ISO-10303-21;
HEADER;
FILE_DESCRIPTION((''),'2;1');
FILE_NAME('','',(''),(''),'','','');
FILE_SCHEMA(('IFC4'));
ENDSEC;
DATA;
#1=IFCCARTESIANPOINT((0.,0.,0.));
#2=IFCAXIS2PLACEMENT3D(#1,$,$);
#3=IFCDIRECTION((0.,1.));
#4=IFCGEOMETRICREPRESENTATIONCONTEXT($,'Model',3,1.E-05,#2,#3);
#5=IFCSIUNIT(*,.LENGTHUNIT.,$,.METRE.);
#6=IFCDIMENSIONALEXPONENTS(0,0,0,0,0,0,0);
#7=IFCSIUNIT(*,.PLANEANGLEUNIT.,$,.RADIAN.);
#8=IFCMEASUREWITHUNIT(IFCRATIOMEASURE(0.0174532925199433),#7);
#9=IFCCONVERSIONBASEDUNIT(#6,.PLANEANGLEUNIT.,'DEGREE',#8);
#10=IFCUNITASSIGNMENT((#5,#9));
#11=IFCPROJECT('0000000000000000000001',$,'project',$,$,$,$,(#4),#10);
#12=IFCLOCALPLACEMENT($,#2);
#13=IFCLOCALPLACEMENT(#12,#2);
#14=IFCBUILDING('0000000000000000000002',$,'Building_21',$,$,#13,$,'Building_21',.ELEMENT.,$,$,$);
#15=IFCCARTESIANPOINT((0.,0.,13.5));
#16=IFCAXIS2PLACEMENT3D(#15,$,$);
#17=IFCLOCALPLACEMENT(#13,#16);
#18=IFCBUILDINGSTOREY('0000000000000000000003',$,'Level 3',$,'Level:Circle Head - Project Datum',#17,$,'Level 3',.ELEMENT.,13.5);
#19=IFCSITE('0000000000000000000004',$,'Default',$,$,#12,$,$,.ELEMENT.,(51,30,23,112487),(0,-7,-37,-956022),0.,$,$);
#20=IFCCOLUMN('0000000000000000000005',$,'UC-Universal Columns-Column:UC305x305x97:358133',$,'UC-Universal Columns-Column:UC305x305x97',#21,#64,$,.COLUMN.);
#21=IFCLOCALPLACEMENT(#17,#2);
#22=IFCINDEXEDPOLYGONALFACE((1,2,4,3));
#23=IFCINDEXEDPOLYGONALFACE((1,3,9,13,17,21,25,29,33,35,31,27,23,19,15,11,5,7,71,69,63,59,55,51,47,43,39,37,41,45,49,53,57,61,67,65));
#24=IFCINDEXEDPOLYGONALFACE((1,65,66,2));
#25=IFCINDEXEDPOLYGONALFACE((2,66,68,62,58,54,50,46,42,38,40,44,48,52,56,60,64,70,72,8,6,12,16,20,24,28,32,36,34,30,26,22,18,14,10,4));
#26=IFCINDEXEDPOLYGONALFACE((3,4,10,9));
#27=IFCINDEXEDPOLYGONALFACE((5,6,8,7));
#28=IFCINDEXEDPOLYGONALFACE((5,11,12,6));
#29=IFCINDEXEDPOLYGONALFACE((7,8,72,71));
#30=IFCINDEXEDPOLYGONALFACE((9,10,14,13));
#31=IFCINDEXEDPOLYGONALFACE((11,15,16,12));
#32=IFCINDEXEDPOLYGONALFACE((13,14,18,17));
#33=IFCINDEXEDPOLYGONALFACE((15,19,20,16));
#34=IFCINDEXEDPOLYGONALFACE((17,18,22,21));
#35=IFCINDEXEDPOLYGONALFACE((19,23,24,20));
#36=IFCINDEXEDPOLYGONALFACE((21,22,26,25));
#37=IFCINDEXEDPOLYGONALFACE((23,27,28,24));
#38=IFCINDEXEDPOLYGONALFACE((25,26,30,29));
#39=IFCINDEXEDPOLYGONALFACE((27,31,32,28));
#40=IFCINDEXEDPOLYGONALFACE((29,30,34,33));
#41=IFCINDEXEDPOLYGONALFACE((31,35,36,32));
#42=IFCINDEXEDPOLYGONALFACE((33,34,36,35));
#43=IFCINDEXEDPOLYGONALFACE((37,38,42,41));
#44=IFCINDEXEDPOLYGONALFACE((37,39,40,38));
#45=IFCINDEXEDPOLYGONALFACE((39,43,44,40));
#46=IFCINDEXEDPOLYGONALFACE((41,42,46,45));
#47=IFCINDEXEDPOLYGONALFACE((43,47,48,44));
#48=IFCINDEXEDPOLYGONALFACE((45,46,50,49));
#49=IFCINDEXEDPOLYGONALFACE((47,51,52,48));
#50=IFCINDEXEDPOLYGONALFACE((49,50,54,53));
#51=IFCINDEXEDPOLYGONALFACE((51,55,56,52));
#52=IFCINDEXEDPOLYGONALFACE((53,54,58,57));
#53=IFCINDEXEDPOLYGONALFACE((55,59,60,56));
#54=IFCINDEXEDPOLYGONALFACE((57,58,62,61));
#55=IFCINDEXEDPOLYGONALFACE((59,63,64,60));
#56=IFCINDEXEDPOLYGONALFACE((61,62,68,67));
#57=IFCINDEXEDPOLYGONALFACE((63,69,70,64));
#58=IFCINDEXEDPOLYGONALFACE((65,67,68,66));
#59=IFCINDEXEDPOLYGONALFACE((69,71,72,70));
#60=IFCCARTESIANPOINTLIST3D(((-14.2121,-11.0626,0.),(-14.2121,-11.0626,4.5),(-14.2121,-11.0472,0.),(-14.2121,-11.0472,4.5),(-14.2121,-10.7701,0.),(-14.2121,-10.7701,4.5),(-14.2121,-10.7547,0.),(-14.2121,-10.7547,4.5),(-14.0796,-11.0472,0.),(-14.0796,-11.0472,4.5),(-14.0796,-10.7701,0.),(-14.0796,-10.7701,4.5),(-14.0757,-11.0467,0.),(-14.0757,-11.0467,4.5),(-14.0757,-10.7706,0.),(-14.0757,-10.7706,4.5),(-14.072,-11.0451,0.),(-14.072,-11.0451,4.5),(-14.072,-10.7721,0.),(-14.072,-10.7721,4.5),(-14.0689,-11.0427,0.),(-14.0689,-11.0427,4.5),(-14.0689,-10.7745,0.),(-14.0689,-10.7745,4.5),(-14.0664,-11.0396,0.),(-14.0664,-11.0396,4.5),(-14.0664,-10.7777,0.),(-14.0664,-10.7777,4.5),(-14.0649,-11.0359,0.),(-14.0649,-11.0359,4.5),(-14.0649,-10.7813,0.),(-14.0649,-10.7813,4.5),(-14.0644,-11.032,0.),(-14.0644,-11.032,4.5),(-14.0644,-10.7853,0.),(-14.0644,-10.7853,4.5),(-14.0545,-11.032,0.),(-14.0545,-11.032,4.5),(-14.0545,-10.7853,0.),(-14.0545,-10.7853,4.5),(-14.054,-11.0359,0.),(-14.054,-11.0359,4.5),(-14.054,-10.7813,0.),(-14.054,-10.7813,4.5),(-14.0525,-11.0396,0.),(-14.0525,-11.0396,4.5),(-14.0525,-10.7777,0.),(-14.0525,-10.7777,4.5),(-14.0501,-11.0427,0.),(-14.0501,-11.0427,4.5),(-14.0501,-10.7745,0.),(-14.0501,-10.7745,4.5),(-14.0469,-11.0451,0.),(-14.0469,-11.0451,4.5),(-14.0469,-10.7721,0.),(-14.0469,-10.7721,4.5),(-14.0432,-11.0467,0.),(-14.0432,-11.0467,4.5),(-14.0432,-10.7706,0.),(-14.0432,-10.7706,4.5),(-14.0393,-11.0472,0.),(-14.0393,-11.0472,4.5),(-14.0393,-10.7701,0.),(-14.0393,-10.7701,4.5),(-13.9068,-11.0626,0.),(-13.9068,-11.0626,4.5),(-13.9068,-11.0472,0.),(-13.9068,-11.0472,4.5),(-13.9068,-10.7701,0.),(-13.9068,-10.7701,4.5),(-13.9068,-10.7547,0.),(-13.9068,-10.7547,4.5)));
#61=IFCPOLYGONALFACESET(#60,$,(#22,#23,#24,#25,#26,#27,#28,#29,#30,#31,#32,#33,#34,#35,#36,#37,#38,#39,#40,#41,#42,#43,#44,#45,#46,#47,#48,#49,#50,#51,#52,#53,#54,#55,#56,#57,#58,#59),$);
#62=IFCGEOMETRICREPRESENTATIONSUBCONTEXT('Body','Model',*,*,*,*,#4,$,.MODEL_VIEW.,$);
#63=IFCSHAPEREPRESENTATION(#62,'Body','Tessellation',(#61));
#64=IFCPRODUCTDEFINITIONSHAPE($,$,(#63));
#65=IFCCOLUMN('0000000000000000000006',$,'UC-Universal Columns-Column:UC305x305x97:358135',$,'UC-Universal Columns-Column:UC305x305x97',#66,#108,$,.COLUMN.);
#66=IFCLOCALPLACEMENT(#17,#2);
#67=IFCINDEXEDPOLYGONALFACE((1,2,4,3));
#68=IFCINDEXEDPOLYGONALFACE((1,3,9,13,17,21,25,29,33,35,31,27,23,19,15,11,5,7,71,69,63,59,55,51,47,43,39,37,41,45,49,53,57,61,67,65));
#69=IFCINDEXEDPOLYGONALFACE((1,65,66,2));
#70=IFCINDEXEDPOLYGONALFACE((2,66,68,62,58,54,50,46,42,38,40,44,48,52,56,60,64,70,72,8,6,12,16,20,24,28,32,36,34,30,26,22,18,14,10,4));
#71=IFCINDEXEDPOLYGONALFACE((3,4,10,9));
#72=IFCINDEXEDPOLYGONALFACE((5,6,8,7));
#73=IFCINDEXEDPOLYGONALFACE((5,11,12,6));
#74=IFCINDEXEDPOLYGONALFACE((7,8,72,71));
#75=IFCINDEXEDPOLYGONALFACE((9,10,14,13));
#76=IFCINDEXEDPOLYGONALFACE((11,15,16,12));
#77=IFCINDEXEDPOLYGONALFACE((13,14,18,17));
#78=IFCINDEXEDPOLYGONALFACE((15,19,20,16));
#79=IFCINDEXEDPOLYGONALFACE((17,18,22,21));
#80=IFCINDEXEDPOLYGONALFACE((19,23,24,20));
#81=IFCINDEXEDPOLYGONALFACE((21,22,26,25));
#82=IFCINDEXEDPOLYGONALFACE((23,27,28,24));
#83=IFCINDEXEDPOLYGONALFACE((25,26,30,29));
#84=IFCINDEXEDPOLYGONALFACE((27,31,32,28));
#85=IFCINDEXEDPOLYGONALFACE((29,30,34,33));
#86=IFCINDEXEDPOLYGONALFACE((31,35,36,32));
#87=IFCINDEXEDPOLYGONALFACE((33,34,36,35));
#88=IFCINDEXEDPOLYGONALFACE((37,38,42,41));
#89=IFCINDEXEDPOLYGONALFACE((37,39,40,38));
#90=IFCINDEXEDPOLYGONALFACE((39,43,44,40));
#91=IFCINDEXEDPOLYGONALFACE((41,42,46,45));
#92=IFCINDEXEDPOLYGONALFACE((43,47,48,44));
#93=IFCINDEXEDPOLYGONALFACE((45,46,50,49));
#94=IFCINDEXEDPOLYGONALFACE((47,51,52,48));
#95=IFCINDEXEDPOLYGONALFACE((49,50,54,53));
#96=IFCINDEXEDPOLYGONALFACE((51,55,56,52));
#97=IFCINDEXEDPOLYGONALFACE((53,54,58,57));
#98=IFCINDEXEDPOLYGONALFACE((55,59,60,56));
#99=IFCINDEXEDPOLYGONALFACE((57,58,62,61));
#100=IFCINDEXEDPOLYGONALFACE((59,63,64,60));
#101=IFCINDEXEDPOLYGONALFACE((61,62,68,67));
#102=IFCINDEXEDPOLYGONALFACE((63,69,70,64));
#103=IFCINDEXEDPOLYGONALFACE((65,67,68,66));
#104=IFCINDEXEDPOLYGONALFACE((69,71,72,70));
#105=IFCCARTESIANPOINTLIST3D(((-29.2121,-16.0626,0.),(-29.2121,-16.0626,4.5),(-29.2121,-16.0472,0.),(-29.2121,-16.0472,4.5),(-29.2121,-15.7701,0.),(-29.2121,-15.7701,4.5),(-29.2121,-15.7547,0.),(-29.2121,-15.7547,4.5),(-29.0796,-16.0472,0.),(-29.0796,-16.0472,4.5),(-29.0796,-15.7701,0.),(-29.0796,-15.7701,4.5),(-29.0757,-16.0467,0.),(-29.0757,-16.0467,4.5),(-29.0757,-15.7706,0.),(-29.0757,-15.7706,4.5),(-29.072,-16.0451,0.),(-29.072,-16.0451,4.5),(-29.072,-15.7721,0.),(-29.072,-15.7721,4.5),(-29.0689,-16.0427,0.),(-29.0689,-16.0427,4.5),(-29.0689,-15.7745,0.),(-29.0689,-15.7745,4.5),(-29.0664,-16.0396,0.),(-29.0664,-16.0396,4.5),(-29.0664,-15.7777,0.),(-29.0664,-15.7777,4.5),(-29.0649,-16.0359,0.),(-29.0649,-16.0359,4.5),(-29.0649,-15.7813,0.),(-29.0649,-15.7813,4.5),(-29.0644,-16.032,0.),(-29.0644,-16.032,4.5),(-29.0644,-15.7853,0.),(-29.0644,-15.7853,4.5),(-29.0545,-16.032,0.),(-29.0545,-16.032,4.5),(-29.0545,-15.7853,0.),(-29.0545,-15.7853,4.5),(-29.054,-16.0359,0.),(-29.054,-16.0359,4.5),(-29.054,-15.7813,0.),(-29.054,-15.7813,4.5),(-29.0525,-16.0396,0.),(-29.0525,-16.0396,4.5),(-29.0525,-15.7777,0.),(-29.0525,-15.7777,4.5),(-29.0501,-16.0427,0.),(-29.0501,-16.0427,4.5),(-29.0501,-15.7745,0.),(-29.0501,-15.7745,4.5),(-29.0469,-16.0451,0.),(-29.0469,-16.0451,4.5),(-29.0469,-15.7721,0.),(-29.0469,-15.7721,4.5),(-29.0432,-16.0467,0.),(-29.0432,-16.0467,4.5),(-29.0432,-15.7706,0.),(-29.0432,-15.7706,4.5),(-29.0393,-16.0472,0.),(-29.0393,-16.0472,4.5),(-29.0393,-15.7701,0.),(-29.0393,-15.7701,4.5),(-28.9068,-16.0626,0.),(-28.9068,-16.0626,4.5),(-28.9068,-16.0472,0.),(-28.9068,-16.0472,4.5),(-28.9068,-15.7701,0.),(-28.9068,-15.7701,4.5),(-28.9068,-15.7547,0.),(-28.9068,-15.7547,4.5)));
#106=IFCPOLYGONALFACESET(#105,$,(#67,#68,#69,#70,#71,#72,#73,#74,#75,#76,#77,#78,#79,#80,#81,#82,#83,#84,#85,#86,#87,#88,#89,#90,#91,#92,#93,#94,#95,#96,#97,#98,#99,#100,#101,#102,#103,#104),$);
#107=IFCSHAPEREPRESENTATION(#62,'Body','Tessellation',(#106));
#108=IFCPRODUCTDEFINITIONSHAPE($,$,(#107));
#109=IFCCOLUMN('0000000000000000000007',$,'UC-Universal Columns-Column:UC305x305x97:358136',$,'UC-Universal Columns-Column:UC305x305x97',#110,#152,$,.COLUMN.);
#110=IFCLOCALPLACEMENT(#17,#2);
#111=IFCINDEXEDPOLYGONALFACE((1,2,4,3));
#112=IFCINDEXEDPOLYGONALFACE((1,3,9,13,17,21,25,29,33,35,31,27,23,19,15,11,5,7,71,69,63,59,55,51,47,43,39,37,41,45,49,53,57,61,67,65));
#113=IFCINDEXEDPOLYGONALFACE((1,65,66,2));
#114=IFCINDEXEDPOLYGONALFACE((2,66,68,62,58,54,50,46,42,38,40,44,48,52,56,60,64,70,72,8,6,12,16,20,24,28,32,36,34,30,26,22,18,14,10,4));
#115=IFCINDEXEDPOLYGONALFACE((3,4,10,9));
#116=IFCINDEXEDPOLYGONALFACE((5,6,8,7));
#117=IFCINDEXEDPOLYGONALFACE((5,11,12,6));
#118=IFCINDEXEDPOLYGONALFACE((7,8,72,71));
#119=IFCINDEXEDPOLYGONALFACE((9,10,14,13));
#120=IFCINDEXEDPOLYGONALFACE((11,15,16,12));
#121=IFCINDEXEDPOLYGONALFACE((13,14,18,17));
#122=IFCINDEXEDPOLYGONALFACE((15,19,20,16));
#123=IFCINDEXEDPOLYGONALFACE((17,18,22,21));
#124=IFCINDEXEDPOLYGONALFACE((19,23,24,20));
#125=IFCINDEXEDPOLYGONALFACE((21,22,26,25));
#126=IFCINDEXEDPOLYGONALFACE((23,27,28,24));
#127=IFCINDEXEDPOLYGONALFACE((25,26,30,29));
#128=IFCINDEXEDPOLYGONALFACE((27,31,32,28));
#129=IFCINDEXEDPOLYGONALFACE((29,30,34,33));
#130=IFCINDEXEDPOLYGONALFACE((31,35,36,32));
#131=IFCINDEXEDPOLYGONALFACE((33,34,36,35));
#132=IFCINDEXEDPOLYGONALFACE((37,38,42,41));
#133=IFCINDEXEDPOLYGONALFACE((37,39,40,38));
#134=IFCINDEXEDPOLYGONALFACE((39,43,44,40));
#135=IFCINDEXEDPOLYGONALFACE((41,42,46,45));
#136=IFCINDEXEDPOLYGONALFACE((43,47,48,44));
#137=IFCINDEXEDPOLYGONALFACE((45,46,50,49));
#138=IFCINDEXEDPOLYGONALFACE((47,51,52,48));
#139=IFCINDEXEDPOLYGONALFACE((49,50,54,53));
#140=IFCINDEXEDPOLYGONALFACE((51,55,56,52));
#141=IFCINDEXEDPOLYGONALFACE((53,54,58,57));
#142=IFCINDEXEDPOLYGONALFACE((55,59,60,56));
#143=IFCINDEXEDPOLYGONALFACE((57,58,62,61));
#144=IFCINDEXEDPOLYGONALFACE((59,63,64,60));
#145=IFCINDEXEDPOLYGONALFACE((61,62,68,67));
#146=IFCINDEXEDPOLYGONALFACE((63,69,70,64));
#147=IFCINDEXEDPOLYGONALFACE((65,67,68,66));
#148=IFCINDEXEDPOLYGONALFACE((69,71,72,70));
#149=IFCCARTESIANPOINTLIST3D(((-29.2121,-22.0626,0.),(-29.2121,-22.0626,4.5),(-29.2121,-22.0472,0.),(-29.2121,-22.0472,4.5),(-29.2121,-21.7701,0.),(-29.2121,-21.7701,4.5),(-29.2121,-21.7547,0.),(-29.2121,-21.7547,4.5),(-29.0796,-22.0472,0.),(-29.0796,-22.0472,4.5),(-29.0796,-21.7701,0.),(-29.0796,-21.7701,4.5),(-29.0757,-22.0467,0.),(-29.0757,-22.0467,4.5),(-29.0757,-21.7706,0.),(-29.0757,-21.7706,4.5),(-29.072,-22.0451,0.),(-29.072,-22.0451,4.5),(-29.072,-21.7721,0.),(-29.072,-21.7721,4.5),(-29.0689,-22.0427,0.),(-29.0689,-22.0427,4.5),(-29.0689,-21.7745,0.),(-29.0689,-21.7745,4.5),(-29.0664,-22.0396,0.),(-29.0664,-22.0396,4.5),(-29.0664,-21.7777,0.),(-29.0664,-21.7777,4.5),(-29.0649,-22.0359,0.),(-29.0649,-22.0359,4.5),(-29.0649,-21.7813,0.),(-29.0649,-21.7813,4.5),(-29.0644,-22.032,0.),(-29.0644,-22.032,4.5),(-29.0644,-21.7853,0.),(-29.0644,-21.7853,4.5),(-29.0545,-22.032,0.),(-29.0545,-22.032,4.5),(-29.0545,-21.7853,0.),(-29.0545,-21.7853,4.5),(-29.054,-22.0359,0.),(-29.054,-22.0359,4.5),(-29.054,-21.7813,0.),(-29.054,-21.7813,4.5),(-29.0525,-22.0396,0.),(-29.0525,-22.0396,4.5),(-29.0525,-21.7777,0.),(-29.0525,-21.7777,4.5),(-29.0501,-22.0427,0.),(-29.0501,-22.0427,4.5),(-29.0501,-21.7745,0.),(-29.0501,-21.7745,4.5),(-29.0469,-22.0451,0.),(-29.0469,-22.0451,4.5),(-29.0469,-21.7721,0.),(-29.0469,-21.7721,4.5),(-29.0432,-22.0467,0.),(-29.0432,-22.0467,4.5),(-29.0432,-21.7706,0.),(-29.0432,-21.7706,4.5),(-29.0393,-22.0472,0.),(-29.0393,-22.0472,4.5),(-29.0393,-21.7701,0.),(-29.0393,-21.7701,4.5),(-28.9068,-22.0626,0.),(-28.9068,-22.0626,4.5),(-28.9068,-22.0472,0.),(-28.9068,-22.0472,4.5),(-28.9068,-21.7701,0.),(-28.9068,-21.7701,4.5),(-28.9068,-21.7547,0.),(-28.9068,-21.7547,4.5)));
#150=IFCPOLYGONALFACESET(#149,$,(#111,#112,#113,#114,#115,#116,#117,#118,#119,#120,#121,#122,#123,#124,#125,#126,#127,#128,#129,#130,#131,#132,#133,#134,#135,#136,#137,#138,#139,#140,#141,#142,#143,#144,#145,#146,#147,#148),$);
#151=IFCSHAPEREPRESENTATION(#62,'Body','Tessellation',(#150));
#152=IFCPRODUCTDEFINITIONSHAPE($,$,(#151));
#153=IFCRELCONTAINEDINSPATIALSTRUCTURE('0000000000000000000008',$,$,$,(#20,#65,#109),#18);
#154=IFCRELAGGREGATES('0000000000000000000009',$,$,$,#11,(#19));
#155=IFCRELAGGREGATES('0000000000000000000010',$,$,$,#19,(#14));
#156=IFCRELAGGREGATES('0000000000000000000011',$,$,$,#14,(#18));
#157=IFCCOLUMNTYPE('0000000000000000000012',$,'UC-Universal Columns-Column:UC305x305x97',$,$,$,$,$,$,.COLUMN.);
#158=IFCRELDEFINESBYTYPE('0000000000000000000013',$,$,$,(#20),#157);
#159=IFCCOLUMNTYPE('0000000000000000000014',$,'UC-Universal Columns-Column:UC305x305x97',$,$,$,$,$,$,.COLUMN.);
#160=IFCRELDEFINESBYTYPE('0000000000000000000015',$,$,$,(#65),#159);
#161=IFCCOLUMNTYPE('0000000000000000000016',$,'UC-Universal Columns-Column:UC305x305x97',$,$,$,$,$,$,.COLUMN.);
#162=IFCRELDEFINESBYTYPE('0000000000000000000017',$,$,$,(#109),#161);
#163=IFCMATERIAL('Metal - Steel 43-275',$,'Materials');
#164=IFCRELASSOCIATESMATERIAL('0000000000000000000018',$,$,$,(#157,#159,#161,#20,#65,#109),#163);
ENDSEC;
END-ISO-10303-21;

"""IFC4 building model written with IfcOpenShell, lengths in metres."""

from ifc_helpers import new_model, entity, si_unit, converted_unit, direction, frame, frame_2d, origin, place, context, subcontext, project, spatial, polyline, circle_curve, parameter, trimmed, segment, composite_curve, i_section, outline, extrude, source, transform, mapped, material, material_profile, profile_set, profile_usage, type_object, type_shapes, element, save


model = new_model("IFC4")

# Units and contexts
model_context = context("Model", 3, precision=1e-05, world=origin(), true_north=direction((0.0, 1.0)))
body_context = subcontext(model_context, "Body", "Model", "MODEL_VIEW")
ifc_project = project(units=[si_unit("LENGTHUNIT", "METRE"), converted_unit("PLANEANGLEUNIT", "DEGREE", entity("IfcRatioMeasure", 0.0174532925199433), si_unit("PLANEANGLEUNIT", "RADIAN"), dimensions=[0, 0, 0, 0, 0, 0, 0])], contexts=[model_context])

# Site, building, storey
site_placement = place(None, origin())
site = spatial("IfcSite", under=ifc_project, at=site_placement, Name="Default", CompositionType="ELEMENT", RefLatitude=(51, 30, 23, 112487), RefLongitude=(0, -7, -37, -956022), RefElevation=0.0)
building_placement = place(site_placement, origin())
building = spatial("IfcBuilding", under=site, at=building_placement, Name="Building_21", LongName="Building_21", CompositionType="ELEMENT")
storey_placement = place(building_placement, frame((0.0, 0.0, 13.5)))
storey = spatial("IfcBuildingStorey", under=building, at=storey_placement, Name="Level 3", ObjectType="Level:Circle Head - Project Datum", LongName="Level 3", CompositionType="ELEMENT", Elevation=13.5)

# Columns
ifc_material_1 = material(Name="Metal - Steel 43-275", Category="Materials")
ifc_material_profile_1 = material_profile(ifc_material_1, outline(composite_curve([segment(polyline([(-0.1527, 0.154, 0.0), (0.1527, 0.154, 0.0)]), True, "CONTINUOUS"), segment(polyline([(0.1527, 0.154, 0.0), (0.1527, 0.1386, 0.0)]), True, "CONTINUOUS"), segment(polyline([(0.1527, 0.1386, 0.0), (0.0201, 0.1386, 0.0)]), True, "CONTINUOUS"), segment(trimmed(circle_curve(frame((0.0201, 0.1234, 0.0)), 0.0152), [parameter(90.0)], [parameter(180.0)], True, "PARAMETER"), True, "CONTINUOUS"), segment(polyline([(0.0049, 0.1234, 0.0), (0.0049, -0.1234, 0.0)]), True, "CONTINUOUS"), segment(trimmed(circle_curve(frame((0.0201, -0.1234, 0.0)), 0.0152), [parameter(180.0)], [parameter(270.0)], True, "PARAMETER"), True, "CONTINUOUS"), segment(polyline([(0.0201, -0.1386, 0.0), (0.1527, -0.1386, 0.0)]), True, "CONTINUOUS"), segment(polyline([(0.1527, -0.1386, 0.0), (0.1527, -0.154, 0.0)]), True, "CONTINUOUS"), segment(polyline([(0.1527, -0.154, 0.0), (-0.1527, -0.154, 0.0)]), True, "CONTINUOUS"), segment(polyline([(-0.1527, -0.154, 0.0), (-0.1527, -0.1386, 0.0)]), True, "CONTINUOUS"), segment(polyline([(-0.1527, -0.1386, 0.0), (-0.0201, -0.1386, 0.0)]), True, "CONTINUOUS"), segment(trimmed(circle_curve(frame((-0.0201, -0.1234, 0.0)), 0.0152), [parameter(270.0)], [parameter(0.0)], True, "PARAMETER"), True, "CONTINUOUS"), segment(polyline([(-0.0049, -0.1234, 0.0), (-0.005, 0.1234, 0.0)]), True, "CONTINUOUS"), segment(trimmed(circle_curve(frame((-0.0201, 0.1234, 0.0)), 0.0152), [parameter(0.0)], [parameter(90.0)], True, "PARAMETER"), True, "CONTINUOUS"), segment(polyline([(-0.0201, 0.1386, 0.0), (-0.1527, 0.1386, 0.0)]), True, "CONTINUOUS"), segment(polyline([(-0.1527, 0.1386, 0.0), (-0.1527, 0.154, 0.0)]), True, "CONTINUOUS")], self_intersect=False), kind="CURVE"), Name="UC305x305x97")
ifc_material_profile_2 = material_profile(ifc_material_1, outline(composite_curve([segment(polyline([(0.1527, 0.154, 0.0), (0.1527, 0.1386, 0.0)]), True, "CONTINUOUS"), segment(polyline([(0.1527, 0.1386, 0.0), (0.0049, 0.1386, 0.0)]), True, "CONTINUOUS"), segment(polyline([(0.0049, 0.1386, 0.0), (0.0049, -0.1386, 0.0)]), True, "CONTINUOUS"), segment(polyline([(0.0049, -0.1386, 0.0), (0.1527, -0.1386, 0.0)]), True, "CONTINUOUS"), segment(polyline([(0.1527, -0.1386, 0.0), (0.1527, -0.154, 0.0)]), True, "CONTINUOUS"), segment(polyline([(0.1527, -0.154, 0.0), (-0.1527, -0.154, 0.0)]), True, "CONTINUOUS"), segment(polyline([(-0.1527, -0.154, 0.0), (-0.1527, -0.1386, 0.0)]), True, "CONTINUOUS"), segment(polyline([(-0.1527, -0.1386, 0.0), (-0.005, -0.1386, 0.0)]), True, "CONTINUOUS"), segment(polyline([(-0.005, -0.1386, 0.0), (-0.005, 0.1386, 0.0)]), True, "CONTINUOUS"), segment(polyline([(-0.005, 0.1386, 0.0), (-0.1527, 0.1386, 0.0)]), True, "CONTINUOUS"), segment(polyline([(-0.1527, 0.1386, 0.0), (-0.1527, 0.154, 0.0)]), True, "CONTINUOUS"), segment(polyline([(-0.1527, 0.154, 0.0), (0.1527, 0.154, 0.0)]), True, "CONTINUOUS")], self_intersect=False), kind="CURVE"), Name="UC305x305x97")
ifc_profile_set = profile_set([ifc_material_profile_1, ifc_material_profile_2], Name="UC305x305x97")
ifc_profile_usage_1 = profile_usage(ifc_profile_set)
column_type_1 = type_object("IfcColumnType", Name="UC-Universal Columns-Column:UC305x305x97", PredefinedType="COLUMN", material=ifc_profile_set)
shared_shape_1 = source(origin(), body_context, "Body", "SweptSolid", [
    extrude(i_section(OverallWidth=0.3053, OverallDepth=0.3079, WebThickness=0.0099, FlangeThickness=0.0154, FilletRadius=0.0152, at=frame_2d((0.0, 0.0), x_axis=(0.0, 1.0))), frame((-14.0595, -10.9086, 13.5), z_axis=(0.0, 0.0, 1.0), x_axis=(0.0, -1.0, 0.0)), (0.0, 0.0, 1.0), 4.5),
])
type_shapes(column_type_1, [shared_shape_1])
column_1_placement = place(storey_placement, frame((0.0, 0.0, -13.5)))
element("IfcColumn", 1, at=column_1_placement, inside=storey, type_object=column_type_1, material=ifc_profile_usage_1, Name="UC-Universal Columns-Column:UC305x305x97:358133", ObjectType="UC-Universal Columns-Column:UC305x305x97", PredefinedType="COLUMN", context=body_context, shape_type="MappedRepresentation", body=[
    mapped(shared_shape_1, transform((0.0, 0.0, 0.0), scale=1.0)),
])
ifc_profile_usage_2 = profile_usage(ifc_profile_set)
column_type_2 = type_object("IfcColumnType", Name="UC-Universal Columns-Column:UC305x305x97", PredefinedType="COLUMN", material=ifc_profile_set)
shared_shape_2 = source(origin(), body_context, "Body", "SweptSolid", [
    extrude(i_section(OverallWidth=0.3053, OverallDepth=0.3079, WebThickness=0.0099, FlangeThickness=0.0154, FilletRadius=0.0152, at=frame_2d((0.0, 0.0), x_axis=(0.0, 1.0))), frame((-29.0595, -15.9086, 13.5), z_axis=(0.0, 0.0, 1.0), x_axis=(0.0, -1.0, 0.0)), (0.0, 0.0, 1.0), 4.5),
])
type_shapes(column_type_2, [shared_shape_2])
column_2_placement = place(storey_placement, frame((0.0, 0.0, -13.5)))
element("IfcColumn", 2, at=column_2_placement, inside=storey, type_object=column_type_2, material=ifc_profile_usage_2, Name="UC-Universal Columns-Column:UC305x305x97:358135", ObjectType="UC-Universal Columns-Column:UC305x305x97", PredefinedType="COLUMN", context=body_context, shape_type="MappedRepresentation", body=[
    mapped(shared_shape_2, transform((0.0, 0.0, 0.0), scale=1.0)),
])
ifc_profile_usage_3 = profile_usage(ifc_profile_set)
column_type_3 = type_object("IfcColumnType", Name="UC-Universal Columns-Column:UC305x305x97", PredefinedType="COLUMN", material=ifc_profile_set)
shared_shape_3 = source(origin(), body_context, "Body", "SweptSolid", [
    extrude(i_section(OverallWidth=0.3053, OverallDepth=0.3079, WebThickness=0.0099, FlangeThickness=0.0154, FilletRadius=0.0152, at=frame_2d((0.0, 0.0), x_axis=(0.0, 1.0))), frame((-29.0595, -21.9086, 13.5), z_axis=(0.0, 0.0, 1.0), x_axis=(0.0, -1.0, 0.0)), (0.0, 0.0, 1.0), 4.5),
])
type_shapes(column_type_3, [shared_shape_3])
column_3_placement = place(storey_placement, frame((0.0, 0.0, -13.5)))
element("IfcColumn", 3, at=column_3_placement, inside=storey, type_object=column_type_3, material=ifc_profile_usage_3, Name="UC-Universal Columns-Column:UC305x305x97:358136", ObjectType="UC-Universal Columns-Column:UC305x305x97", PredefinedType="COLUMN", context=body_context, shape_type="MappedRepresentation", body=[
    mapped(shared_shape_3, transform((0.0, 0.0, 0.0), scale=1.0)),
])

save(model, "model.ifc")
